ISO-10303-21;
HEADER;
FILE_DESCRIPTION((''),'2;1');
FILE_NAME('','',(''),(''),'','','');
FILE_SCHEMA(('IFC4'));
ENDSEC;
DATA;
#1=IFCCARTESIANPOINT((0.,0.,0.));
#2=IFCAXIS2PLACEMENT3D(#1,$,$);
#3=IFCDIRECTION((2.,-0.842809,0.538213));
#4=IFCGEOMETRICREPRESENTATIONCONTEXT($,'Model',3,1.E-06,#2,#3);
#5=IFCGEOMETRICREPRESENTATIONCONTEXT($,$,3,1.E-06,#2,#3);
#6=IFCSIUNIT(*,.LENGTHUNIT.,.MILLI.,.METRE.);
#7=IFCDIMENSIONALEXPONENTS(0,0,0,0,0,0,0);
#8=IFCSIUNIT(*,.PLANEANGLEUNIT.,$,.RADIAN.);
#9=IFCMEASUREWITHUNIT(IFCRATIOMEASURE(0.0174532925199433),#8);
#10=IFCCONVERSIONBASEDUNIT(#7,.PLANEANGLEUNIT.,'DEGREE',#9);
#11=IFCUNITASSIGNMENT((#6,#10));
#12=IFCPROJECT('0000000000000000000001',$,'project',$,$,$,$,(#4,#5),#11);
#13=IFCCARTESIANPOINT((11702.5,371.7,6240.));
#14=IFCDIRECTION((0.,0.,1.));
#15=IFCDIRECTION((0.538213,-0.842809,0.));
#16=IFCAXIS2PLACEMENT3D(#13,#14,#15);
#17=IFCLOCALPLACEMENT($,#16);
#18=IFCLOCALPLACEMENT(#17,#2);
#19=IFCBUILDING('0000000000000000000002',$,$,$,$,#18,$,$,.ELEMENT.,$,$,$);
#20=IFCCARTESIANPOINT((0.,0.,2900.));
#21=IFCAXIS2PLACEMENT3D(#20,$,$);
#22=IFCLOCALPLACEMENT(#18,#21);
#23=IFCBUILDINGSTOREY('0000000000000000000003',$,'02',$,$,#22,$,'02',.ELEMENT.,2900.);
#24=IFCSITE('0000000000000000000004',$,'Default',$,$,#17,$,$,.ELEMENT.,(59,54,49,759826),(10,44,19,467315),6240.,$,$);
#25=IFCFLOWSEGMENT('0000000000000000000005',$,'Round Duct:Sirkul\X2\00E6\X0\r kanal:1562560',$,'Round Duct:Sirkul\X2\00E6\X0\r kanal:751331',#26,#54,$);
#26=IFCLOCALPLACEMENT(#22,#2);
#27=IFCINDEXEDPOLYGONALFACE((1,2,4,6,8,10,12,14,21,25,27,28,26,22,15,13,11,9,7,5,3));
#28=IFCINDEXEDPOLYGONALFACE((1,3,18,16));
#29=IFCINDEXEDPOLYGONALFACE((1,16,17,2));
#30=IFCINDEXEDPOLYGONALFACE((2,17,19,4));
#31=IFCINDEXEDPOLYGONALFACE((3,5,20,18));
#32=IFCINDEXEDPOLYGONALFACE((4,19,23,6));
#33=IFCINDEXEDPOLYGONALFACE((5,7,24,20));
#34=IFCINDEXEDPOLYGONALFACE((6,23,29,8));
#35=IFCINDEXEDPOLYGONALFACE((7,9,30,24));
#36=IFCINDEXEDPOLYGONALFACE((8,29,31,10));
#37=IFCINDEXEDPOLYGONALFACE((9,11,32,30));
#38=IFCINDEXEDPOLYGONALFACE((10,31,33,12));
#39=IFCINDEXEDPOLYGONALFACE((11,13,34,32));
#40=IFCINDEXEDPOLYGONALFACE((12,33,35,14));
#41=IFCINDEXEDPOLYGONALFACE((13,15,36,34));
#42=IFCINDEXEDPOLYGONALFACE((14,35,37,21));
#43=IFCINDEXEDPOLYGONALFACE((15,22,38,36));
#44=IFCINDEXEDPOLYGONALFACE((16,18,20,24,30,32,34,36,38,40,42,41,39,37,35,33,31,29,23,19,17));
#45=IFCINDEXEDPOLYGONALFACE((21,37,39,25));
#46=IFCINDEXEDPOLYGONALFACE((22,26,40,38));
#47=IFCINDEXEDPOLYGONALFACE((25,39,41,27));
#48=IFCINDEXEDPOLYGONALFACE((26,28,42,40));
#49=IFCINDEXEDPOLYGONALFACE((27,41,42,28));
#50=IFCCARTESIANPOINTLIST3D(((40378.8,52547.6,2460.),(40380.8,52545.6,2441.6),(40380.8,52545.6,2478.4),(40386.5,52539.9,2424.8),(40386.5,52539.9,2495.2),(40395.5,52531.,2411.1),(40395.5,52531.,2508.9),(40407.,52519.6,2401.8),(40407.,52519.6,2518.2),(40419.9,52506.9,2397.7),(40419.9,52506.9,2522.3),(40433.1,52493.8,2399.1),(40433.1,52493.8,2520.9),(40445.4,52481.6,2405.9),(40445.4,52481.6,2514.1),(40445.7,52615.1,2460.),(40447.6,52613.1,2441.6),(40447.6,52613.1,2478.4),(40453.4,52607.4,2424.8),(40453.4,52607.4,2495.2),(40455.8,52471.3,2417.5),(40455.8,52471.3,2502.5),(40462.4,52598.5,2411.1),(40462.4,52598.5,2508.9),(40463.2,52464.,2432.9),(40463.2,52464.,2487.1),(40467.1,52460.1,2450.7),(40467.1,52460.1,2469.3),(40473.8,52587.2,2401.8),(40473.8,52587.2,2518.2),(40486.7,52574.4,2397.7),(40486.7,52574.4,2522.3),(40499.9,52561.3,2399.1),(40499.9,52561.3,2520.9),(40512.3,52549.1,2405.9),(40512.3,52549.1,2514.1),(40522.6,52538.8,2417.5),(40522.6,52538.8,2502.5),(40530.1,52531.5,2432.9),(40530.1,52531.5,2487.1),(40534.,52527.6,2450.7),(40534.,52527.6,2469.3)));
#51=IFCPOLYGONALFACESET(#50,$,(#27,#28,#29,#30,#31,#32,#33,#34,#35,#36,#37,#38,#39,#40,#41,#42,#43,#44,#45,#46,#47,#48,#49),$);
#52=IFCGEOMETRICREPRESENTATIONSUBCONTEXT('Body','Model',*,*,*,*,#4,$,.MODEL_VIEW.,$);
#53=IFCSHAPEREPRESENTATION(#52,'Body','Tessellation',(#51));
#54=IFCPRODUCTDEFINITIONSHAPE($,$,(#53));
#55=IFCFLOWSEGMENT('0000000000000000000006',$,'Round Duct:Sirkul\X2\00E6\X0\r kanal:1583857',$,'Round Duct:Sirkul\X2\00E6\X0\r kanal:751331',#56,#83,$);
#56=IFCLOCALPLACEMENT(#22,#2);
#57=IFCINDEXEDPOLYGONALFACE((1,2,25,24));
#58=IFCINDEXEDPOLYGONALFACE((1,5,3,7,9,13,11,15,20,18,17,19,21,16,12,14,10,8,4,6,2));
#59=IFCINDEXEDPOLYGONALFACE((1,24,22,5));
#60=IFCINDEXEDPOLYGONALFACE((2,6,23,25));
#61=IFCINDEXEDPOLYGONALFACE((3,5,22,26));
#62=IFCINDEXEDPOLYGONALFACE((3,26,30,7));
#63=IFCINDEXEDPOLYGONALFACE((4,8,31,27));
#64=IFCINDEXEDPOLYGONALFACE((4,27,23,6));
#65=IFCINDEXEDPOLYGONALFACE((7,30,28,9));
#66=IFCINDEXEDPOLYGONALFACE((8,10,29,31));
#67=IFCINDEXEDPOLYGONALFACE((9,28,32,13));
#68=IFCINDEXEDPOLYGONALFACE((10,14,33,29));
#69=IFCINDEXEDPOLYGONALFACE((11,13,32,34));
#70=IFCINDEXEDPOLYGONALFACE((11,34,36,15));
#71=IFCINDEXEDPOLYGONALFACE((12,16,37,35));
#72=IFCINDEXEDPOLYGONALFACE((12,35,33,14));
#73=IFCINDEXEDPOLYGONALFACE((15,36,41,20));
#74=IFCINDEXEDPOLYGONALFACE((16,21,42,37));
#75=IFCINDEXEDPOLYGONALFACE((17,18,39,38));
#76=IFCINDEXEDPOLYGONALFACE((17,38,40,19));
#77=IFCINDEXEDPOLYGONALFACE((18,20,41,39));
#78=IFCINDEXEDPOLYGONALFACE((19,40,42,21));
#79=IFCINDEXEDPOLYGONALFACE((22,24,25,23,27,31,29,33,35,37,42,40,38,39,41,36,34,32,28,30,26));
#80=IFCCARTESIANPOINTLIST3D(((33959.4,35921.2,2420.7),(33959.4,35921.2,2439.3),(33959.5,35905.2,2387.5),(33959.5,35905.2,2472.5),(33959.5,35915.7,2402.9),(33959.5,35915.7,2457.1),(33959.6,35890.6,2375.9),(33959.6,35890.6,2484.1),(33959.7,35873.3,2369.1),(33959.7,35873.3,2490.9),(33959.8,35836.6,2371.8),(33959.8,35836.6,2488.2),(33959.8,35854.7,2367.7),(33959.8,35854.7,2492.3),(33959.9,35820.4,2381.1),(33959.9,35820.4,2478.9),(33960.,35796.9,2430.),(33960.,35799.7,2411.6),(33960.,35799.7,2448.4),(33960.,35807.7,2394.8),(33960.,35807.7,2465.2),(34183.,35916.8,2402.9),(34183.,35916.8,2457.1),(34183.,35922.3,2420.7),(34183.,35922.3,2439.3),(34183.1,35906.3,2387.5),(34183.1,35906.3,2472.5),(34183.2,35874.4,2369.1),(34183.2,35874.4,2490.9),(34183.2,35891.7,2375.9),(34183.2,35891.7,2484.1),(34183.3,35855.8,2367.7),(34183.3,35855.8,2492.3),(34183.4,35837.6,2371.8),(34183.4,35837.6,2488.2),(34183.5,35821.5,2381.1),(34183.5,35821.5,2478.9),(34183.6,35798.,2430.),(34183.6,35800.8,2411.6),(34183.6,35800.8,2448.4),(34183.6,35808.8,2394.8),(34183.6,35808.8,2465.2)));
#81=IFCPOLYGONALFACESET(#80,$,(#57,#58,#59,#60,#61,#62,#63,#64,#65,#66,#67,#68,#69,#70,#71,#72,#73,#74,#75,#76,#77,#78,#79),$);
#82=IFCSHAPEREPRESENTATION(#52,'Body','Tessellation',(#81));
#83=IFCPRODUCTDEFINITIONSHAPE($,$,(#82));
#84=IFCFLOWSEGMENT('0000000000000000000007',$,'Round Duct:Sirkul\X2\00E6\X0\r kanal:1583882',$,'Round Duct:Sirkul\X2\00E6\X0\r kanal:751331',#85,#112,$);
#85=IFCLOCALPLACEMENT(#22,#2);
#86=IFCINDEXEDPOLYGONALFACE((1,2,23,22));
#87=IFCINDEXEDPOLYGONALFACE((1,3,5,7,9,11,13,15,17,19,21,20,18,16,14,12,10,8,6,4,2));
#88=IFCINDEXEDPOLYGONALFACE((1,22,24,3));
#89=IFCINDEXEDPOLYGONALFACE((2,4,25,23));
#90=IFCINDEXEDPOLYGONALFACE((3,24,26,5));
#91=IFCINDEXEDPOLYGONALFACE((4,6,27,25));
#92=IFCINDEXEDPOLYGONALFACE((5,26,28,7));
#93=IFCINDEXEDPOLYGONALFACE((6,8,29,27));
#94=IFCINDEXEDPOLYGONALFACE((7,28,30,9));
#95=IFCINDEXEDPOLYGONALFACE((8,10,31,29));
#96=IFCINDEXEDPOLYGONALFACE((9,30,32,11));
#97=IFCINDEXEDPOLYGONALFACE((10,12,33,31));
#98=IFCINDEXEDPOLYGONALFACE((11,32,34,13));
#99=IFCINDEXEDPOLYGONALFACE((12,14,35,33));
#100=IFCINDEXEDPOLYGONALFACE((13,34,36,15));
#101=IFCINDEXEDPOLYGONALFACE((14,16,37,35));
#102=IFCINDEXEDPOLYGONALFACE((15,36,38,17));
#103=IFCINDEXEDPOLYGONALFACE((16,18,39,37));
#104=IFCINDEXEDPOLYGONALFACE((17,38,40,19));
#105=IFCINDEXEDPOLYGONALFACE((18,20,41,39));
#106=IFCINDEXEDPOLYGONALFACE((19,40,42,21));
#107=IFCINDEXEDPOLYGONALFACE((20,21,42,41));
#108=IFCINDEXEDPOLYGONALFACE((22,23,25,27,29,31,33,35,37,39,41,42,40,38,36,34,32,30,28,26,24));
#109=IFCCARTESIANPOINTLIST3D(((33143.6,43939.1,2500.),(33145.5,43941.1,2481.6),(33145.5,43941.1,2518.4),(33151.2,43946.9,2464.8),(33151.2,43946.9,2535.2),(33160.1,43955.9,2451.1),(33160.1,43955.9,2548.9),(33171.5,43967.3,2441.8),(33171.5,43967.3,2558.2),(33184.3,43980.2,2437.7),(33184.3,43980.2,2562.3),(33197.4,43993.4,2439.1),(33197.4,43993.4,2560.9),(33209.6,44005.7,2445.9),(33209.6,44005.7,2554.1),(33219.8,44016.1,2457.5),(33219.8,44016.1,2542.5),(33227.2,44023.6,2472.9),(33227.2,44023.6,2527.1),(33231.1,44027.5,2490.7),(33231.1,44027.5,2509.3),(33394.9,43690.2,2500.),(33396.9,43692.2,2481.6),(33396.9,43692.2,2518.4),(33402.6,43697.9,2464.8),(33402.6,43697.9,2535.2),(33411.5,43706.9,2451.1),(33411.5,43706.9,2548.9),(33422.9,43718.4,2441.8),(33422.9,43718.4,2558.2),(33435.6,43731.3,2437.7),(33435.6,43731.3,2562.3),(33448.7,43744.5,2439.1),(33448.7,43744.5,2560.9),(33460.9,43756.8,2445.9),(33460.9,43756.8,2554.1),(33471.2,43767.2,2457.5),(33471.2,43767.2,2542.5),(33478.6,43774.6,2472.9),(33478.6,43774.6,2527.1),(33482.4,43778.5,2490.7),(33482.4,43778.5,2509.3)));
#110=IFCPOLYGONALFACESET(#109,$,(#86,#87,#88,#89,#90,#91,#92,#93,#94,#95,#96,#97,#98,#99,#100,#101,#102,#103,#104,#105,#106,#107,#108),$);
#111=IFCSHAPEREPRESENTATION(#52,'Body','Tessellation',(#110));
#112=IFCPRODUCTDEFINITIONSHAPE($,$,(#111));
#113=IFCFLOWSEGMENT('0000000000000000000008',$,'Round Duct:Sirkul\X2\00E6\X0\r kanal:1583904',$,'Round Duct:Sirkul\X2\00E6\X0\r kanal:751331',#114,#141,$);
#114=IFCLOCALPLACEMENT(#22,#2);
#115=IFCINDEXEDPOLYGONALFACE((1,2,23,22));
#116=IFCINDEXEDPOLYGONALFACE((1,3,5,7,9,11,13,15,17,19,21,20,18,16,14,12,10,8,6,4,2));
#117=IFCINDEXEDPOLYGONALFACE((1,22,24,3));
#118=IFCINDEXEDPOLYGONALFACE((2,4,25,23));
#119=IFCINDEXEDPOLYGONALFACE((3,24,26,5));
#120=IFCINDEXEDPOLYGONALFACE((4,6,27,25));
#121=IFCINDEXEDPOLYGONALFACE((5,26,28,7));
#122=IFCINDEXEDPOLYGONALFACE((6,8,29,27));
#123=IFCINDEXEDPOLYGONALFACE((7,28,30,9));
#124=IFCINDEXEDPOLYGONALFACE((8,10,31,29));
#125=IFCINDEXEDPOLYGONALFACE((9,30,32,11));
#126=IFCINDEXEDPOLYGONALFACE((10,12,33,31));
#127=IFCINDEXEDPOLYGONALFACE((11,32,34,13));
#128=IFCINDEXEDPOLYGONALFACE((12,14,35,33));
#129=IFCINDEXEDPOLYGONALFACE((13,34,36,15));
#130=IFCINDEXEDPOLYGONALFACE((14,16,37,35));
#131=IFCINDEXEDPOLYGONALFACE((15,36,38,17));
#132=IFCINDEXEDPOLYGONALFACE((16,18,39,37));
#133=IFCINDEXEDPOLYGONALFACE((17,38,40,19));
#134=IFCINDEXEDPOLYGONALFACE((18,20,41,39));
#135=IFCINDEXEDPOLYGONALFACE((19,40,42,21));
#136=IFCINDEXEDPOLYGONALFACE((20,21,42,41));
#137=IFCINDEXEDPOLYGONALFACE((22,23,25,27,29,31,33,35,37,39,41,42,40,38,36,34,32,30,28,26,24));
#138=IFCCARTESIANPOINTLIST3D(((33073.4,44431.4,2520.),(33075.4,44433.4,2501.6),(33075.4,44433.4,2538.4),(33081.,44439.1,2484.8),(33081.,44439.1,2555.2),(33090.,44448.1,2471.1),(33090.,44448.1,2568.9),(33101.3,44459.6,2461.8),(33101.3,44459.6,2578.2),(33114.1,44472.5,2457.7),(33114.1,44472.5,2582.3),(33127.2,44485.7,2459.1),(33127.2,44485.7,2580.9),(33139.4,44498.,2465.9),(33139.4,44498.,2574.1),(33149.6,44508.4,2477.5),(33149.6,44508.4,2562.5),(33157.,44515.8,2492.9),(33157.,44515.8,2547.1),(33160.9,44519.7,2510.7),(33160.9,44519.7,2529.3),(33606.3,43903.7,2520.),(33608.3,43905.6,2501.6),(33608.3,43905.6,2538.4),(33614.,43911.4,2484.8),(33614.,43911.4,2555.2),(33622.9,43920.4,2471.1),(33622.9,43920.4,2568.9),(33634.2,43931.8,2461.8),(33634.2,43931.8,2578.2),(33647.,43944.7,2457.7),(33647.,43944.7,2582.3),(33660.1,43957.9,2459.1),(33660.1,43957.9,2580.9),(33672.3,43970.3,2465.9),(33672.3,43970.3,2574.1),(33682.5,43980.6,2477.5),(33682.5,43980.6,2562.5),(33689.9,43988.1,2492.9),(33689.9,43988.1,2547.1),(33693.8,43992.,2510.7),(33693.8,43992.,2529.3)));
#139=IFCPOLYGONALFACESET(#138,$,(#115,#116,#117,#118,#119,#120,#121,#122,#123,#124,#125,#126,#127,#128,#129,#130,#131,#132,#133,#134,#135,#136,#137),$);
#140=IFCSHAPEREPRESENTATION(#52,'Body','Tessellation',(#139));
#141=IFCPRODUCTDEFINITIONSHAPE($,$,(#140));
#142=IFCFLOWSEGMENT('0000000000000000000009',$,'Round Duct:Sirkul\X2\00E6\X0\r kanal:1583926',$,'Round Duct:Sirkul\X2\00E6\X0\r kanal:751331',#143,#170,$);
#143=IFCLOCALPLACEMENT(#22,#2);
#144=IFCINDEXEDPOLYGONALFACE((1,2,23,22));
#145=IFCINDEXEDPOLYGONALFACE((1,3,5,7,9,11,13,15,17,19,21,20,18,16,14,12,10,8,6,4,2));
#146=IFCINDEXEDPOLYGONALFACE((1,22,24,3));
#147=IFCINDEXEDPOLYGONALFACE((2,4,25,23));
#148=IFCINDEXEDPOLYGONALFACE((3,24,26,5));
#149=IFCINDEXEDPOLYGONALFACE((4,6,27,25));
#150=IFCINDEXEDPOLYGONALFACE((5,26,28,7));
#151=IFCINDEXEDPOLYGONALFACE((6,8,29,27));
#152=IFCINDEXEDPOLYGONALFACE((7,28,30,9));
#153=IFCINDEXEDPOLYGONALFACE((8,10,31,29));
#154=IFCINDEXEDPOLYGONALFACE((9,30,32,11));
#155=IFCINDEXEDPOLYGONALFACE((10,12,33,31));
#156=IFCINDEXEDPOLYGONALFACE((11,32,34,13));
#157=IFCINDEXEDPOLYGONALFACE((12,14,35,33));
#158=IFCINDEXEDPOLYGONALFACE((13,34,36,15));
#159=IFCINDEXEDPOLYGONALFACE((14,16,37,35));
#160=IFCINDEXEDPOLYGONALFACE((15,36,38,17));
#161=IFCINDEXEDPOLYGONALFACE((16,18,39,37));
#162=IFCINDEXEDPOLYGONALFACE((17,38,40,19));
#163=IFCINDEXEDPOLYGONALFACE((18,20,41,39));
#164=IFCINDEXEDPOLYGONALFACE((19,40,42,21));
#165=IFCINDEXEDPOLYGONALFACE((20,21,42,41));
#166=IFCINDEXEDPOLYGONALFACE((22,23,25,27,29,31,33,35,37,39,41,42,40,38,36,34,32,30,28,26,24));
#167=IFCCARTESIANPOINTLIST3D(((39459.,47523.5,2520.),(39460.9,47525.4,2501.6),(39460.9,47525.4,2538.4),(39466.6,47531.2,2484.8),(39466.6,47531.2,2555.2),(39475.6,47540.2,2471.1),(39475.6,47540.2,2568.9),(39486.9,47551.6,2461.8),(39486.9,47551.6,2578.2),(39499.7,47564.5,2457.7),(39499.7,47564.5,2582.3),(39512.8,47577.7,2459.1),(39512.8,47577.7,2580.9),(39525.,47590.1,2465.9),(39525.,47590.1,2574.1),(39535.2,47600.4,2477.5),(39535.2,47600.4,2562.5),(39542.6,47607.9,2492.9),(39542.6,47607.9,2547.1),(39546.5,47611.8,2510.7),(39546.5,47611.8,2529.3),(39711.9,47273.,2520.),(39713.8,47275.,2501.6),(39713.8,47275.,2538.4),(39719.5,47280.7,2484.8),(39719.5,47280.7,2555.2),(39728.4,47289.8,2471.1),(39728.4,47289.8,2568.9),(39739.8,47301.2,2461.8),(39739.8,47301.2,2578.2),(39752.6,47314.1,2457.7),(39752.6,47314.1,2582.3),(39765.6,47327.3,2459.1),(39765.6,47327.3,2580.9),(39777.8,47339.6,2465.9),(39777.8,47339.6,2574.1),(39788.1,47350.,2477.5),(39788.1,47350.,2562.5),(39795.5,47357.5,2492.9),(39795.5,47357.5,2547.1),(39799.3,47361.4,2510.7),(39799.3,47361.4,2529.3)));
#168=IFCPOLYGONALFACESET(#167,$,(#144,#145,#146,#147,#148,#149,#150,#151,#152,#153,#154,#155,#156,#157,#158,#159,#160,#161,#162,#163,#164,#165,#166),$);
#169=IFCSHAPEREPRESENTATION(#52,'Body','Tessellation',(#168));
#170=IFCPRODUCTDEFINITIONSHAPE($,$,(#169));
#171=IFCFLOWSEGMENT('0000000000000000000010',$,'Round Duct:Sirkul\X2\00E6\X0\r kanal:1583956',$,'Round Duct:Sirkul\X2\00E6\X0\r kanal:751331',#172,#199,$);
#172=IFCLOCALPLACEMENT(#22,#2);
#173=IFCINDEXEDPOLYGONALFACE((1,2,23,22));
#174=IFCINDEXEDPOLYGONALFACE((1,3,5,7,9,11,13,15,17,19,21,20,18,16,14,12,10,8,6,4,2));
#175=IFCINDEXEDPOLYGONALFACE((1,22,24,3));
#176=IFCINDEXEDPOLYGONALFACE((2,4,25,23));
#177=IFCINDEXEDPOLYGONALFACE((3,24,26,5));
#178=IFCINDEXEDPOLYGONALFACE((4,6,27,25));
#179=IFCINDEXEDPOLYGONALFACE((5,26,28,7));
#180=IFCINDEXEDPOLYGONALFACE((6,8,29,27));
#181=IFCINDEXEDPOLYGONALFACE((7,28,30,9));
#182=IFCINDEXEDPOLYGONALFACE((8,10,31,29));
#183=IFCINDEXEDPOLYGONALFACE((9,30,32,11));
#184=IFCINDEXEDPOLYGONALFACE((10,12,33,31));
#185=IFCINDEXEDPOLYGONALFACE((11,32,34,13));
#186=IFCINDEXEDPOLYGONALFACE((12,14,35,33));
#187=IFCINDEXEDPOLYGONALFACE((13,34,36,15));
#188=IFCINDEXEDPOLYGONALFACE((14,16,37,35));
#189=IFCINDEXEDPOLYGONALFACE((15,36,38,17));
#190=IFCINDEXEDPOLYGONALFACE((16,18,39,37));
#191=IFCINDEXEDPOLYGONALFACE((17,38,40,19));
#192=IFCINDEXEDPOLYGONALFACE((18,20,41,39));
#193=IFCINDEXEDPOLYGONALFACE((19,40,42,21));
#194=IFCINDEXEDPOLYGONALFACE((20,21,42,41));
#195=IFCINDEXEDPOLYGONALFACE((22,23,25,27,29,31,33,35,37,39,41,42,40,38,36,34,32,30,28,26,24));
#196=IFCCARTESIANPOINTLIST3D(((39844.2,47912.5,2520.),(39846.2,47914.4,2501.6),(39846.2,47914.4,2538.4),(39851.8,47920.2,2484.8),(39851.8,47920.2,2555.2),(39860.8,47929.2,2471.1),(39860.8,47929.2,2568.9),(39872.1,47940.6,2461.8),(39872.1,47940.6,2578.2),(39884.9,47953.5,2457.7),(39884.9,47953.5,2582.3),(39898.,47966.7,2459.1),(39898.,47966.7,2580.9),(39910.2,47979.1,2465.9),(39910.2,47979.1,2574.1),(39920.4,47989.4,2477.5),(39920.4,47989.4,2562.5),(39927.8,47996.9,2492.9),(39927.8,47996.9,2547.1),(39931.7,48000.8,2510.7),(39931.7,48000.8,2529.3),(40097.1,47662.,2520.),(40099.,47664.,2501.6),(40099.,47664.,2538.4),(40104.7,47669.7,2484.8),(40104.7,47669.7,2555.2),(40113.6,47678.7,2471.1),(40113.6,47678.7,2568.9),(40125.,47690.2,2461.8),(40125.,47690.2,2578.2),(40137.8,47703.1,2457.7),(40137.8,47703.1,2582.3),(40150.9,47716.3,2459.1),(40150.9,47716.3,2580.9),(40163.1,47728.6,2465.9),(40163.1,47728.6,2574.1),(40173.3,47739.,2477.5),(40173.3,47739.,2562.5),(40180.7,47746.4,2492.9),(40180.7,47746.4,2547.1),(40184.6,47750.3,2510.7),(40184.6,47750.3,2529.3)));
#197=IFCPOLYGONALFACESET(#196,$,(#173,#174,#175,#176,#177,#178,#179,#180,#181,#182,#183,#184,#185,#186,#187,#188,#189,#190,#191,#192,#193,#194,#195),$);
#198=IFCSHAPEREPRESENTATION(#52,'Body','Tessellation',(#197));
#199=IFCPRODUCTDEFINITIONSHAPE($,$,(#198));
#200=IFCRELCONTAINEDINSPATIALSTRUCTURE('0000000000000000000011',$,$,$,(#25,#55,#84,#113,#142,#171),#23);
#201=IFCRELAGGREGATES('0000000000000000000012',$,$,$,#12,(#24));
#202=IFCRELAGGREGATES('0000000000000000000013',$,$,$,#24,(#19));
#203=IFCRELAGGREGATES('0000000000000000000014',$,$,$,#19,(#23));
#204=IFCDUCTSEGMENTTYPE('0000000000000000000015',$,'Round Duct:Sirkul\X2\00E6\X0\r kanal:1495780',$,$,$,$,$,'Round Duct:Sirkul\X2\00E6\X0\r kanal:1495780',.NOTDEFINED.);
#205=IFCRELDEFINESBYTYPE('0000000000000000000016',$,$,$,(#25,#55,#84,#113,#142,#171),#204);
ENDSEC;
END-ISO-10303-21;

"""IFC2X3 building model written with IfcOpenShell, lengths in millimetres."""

from ifc_helpers import new_model, entity, si_unit, converted_unit, direction, frame, origin, origin_2d_with_axis, place, context, subcontext, project, spatial, circle, extrude, type_object, element, save


model = new_model("IFC2X3")

# Units and contexts
model_context = context("Model", 3, precision=1e-06, world=origin(), true_north=direction((2.0, -0.842809, 0.538213)))
context_of_model = context(None, 3, precision=1e-06, world=origin(), true_north=direction((2.0, -0.842809, 0.538213)))
body_context = subcontext(model_context, "Body", "Model", "MODEL_VIEW")
ifc_project = project(units=[si_unit("LENGTHUNIT", "METRE", prefix="MILLI"), converted_unit("PLANEANGLEUNIT", "DEGREE", entity("IfcRatioMeasure", 0.0174532925199433), si_unit("PLANEANGLEUNIT", "RADIAN"), dimensions=[0, 0, 0, 0, 0, 0, 0])], contexts=[model_context, context_of_model])

# Site, building, storey
site_placement = place(None, frame((11702.5, 371.7, 6240.0), z_axis=(0.0, 0.0, 1.0), x_axis=(0.538213, -0.842809, 0.0)))
site = spatial("IfcSite", under=ifc_project, at=site_placement, Name="Default", CompositionType="ELEMENT", RefLatitude=(59, 54, 49, 759826), RefLongitude=(10, 44, 19, 467315), RefElevation=6240.0)
building_placement = place(site_placement, origin())
building = spatial("IfcBuilding", under=site, at=building_placement, CompositionType="ELEMENT")
storey_placement = place(building_placement, frame((0.0, 0.0, 2900.0)))
storey = spatial("IfcBuildingStorey", under=building, at=storey_placement, Name="02", LongName="02", CompositionType="ELEMENT", Elevation=2900.0)

# Flow segments
duct_segment_type = type_object("IfcDuctSegmentType", Name="Round Duct:Sirkulær kanal:1495780", ElementType="Round Duct:Sirkulær kanal:1495780", PredefinedType="NOTDEFINED")
flow_segment_1_placement = place(storey_placement, origin())
element("IfcFlowSegment", 1, at=flow_segment_1_placement, inside=storey, type_object=duct_segment_type, Name="Round Duct:Sirkulær kanal:1562560", ObjectType="Round Duct:Sirkulær kanal:751331", context=body_context, shape_type="SweptSolid", body=[
    extrude(circle(Radius=62.5, at=origin_2d_with_axis()), frame((40423.2, 52503.6, 2460.0), z_axis=(0.703643, 0.710553, 0.0), x_axis=(-0.710553, 0.703643, 0.0)), (0.0, 0.0, 1.0), 95.0),
])
flow_segment_2_placement = place(storey_placement, origin())
element("IfcFlowSegment", 2, at=flow_segment_2_placement, inside=storey, type_object=duct_segment_type, Name="Round Duct:Sirkulær kanal:1583857", ObjectType="Round Duct:Sirkulær kanal:751331", context=body_context, shape_type="SweptSolid", body=[
    extrude(circle(Radius=62.5, at=origin_2d_with_axis()), frame((33959.7, 35859.4, 2430.0), z_axis=(0.999988, 0.004887, 0.0), x_axis=(0.004887, -0.999988, 0.0)), (0.0, 0.0, 1.0), 223.6),
])
flow_segment_3_placement = place(storey_placement, origin())
element("IfcFlowSegment", 3, at=flow_segment_3_placement, inside=storey, type_object=duct_segment_type, Name="Round Duct:Sirkulær kanal:1583882", ObjectType="Round Duct:Sirkulær kanal:751331", context=body_context, shape_type="SweptSolid", body=[
    extrude(circle(Radius=62.5, at=origin_2d_with_axis()), frame((33187.6, 43983.5, 2500.0), z_axis=(0.710554, -0.703643, 0.0), x_axis=(-0.703643, -0.710554, 0.0)), (0.0, 0.0, 1.0), 353.8),
])
flow_segment_4_placement = place(storey_placement, origin())
element("IfcFlowSegment", 4, at=flow_segment_4_placement, inside=storey, type_object=duct_segment_type, Name="Round Duct:Sirkulær kanal:1583904", ObjectType="Round Duct:Sirkulær kanal:751331", context=body_context, shape_type="SweptSolid", body=[
    extrude(circle(Radius=62.5, at=origin_2d_with_axis()), frame((33117.4, 44475.8, 2520.0), z_axis=(0.710554, -0.703643, 0.0), x_axis=(-0.703643, -0.710554, 0.0)), (0.0, 0.0, 1.0), 750.0),
])
flow_segment_5_placement = place(storey_placement, origin())
element("IfcFlowSegment", 5, at=flow_segment_5_placement, inside=storey, type_object=duct_segment_type, Name="Round Duct:Sirkulær kanal:1583926", ObjectType="Round Duct:Sirkulær kanal:751331", context=body_context, shape_type="SweptSolid", body=[
    extrude(circle(Radius=62.5, at=origin_2d_with_axis()), frame((39755.9, 47317.4, 2520.0), z_axis=(-0.710554, 0.703643, 0.0), x_axis=(-0.703643, -0.710554, 0.0)), (0.0, 0.0, 1.0), 355.9),
])
flow_segment_6_placement = place(storey_placement, origin())
element("IfcFlowSegment", 6, at=flow_segment_6_placement, inside=storey, type_object=duct_segment_type, Name="Round Duct:Sirkulær kanal:1583956", ObjectType="Round Duct:Sirkulær kanal:751331", context=body_context, shape_type="SweptSolid", body=[
    extrude(circle(Radius=62.5, at=origin_2d_with_axis()), frame((40141.1, 47706.4, 2520.0), z_axis=(-0.710554, 0.703643, 0.0), x_axis=(-0.703643, -0.710554, 0.0)), (0.0, 0.0, 1.0), 355.9),
])

save(model, "model.ifc")
